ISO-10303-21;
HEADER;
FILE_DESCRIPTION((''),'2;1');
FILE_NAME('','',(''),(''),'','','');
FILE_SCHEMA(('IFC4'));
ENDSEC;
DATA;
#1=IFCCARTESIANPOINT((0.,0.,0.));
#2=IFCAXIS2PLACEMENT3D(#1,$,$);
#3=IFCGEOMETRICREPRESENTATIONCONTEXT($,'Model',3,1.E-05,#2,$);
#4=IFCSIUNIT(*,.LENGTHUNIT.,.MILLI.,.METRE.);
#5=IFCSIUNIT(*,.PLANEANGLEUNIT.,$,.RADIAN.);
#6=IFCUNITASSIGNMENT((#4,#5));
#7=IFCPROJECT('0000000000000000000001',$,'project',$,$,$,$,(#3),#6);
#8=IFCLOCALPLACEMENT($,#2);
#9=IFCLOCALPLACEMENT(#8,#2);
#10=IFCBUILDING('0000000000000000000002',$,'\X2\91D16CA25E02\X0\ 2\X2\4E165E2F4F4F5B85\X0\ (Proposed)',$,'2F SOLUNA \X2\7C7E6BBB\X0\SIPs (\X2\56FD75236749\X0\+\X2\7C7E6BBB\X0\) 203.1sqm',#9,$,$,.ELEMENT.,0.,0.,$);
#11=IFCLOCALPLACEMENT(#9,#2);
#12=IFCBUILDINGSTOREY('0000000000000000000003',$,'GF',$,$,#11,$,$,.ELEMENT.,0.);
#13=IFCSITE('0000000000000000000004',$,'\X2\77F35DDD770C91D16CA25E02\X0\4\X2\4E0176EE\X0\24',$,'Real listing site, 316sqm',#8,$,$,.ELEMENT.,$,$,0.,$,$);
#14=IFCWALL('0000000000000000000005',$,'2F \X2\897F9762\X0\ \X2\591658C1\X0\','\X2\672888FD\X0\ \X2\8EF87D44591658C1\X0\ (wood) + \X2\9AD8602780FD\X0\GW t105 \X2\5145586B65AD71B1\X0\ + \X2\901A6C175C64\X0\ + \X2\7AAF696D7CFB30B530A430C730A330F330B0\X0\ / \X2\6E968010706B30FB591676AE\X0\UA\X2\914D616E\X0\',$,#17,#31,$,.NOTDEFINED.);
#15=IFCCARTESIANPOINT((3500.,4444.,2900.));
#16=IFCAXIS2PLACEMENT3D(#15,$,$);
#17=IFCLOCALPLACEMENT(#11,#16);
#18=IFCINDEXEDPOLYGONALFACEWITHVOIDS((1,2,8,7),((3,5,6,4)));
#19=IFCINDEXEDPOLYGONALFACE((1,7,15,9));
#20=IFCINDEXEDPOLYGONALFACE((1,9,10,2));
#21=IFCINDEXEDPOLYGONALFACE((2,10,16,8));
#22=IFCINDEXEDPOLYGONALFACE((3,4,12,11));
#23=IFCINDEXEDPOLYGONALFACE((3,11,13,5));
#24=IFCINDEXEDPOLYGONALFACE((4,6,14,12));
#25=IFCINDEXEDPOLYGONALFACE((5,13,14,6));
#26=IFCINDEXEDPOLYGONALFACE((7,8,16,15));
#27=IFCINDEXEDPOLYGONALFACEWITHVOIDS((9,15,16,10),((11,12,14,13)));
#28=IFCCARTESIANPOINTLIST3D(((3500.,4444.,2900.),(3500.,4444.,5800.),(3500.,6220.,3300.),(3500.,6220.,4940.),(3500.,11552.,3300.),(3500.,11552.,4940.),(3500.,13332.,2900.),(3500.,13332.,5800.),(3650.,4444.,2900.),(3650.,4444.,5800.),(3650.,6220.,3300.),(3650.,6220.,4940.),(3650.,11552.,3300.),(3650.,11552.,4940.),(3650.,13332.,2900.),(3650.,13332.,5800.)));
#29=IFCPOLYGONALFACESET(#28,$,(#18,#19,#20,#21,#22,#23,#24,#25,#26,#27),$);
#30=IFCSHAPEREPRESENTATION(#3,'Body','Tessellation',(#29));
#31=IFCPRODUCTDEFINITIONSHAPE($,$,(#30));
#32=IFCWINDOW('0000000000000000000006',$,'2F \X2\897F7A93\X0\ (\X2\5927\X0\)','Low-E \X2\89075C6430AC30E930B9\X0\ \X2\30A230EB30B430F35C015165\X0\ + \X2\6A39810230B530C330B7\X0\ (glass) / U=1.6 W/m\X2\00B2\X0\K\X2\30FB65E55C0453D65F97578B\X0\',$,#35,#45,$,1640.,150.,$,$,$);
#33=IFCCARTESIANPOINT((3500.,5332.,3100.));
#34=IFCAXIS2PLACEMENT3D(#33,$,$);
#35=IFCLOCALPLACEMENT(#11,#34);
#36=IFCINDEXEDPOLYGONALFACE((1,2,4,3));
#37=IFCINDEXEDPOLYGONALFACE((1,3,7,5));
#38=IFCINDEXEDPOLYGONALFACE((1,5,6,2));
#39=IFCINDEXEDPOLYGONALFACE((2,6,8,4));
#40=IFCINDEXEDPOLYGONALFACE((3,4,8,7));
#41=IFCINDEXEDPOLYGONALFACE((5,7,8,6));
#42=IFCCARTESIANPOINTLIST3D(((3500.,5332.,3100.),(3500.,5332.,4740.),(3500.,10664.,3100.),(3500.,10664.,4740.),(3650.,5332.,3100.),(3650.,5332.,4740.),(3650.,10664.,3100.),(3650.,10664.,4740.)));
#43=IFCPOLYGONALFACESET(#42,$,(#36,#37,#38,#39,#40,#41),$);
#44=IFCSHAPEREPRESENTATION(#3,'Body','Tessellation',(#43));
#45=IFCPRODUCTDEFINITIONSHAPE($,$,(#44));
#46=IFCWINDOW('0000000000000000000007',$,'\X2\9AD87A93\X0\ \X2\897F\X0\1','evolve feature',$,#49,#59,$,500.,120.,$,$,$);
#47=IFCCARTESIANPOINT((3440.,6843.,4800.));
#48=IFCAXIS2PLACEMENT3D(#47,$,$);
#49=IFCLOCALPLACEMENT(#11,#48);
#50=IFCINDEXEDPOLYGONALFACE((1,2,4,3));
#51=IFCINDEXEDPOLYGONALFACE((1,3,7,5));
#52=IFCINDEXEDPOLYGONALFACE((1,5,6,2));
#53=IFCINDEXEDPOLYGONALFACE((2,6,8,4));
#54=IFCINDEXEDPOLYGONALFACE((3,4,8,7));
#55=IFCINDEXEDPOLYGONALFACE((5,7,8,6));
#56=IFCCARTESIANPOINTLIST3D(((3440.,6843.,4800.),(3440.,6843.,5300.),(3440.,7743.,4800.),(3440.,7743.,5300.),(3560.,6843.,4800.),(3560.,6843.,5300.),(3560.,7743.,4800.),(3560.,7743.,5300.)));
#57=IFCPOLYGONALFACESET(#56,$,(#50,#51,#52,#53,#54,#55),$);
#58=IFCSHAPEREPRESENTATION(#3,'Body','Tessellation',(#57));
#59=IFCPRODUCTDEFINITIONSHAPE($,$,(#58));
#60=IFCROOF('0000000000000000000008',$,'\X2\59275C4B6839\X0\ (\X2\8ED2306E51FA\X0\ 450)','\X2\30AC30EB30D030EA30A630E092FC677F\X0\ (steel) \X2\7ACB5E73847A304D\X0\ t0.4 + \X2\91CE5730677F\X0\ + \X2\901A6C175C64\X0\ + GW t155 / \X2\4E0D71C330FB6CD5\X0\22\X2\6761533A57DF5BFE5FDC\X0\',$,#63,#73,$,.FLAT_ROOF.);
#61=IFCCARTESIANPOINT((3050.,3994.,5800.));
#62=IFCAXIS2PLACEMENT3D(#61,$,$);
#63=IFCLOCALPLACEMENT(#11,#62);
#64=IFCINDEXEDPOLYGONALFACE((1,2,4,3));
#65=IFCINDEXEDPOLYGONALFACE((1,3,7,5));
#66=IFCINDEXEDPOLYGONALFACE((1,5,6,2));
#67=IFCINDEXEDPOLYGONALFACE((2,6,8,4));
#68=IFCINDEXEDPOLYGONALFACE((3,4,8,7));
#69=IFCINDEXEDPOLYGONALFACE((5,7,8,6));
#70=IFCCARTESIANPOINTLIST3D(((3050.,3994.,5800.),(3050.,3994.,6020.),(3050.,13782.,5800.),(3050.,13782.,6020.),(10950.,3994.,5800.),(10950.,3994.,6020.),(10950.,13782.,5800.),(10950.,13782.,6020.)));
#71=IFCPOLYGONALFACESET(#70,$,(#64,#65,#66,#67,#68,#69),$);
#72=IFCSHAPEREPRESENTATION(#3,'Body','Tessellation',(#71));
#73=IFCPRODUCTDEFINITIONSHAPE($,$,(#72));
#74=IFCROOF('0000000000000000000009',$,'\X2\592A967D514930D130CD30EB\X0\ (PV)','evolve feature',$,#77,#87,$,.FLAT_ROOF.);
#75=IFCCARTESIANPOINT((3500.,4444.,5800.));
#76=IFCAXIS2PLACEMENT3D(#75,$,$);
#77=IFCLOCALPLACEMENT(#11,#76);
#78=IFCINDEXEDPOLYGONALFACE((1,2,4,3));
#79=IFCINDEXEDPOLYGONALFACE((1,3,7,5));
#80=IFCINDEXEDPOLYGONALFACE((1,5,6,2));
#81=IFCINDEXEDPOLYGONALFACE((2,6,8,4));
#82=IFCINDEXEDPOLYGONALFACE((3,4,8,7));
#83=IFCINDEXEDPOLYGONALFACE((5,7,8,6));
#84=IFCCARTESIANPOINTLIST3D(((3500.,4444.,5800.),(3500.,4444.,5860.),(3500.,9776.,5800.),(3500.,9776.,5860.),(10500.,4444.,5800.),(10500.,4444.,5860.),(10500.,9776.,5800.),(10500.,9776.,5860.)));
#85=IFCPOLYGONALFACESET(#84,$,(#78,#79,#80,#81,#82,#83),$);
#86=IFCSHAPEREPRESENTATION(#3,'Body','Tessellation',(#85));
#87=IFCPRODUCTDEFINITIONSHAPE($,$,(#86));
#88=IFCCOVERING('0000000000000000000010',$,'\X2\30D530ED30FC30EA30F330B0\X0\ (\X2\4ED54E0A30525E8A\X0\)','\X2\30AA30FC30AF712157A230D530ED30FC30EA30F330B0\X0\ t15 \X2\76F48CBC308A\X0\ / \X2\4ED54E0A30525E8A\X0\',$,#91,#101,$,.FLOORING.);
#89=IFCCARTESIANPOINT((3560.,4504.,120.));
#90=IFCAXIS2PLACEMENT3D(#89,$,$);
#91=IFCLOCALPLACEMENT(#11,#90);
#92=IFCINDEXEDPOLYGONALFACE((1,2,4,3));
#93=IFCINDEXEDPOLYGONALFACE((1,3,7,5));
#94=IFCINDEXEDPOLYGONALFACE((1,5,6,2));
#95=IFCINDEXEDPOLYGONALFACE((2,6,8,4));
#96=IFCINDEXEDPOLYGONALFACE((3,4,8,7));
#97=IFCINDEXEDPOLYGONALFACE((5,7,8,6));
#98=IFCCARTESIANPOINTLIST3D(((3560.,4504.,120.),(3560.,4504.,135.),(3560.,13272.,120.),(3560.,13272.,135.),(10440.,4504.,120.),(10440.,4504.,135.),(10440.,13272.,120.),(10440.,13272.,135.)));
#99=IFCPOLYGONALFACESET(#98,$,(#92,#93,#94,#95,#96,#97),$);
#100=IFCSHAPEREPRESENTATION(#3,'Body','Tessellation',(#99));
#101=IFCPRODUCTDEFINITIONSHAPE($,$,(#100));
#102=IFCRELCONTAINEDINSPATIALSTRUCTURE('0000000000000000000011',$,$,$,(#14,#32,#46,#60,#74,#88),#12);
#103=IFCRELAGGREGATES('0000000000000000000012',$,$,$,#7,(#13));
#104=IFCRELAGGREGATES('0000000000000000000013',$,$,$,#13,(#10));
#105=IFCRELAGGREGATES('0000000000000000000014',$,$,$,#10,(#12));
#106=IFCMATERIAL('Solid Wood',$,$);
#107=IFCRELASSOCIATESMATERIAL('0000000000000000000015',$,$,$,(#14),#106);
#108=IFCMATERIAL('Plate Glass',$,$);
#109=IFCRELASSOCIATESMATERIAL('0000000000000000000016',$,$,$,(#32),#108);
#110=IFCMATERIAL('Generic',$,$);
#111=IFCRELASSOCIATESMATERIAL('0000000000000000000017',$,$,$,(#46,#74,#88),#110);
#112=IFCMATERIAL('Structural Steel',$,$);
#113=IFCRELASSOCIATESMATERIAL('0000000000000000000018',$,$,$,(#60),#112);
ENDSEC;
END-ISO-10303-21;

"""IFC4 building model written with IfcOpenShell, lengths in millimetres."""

from ifc_helpers import new_model, si_unit, frame, frame_2d, origin, place, context, project, spatial, rectangle, extrude, material, element, fill, save


model = new_model("IFC4")

# Units and contexts
model_context = context("Model", 3, precision=1e-05, world=origin())
ifc_project = project(units=[si_unit("LENGTHUNIT", "METRE", prefix="MILLI"), si_unit("PLANEANGLEUNIT", "RADIAN")], contexts=[model_context])

# Site, building, storey
site_placement = place(None, origin())
site = spatial("IfcSite", under=ifc_project, at=site_placement, Name="石川県金沢市4丁目24", ObjectType="Real listing site, 316sqm", CompositionType="ELEMENT", RefElevation=0.0)
building_placement = place(site_placement, origin())
building = spatial("IfcBuilding", under=site, at=building_placement, Name="金沢市 2世帯住宅 (Proposed)", ObjectType="2F SOLUNA 籾殻SIPs (国産杉+籾殻) 203.1sqm", CompositionType="ELEMENT", ElevationOfRefHeight=0.0, ElevationOfTerrain=0.0)
storey_placement = place(building_placement, origin())
storey = spatial("IfcBuildingStorey", under=building, at=storey_placement, Name="GF", CompositionType="ELEMENT", Elevation=0.0)

# Shared definitions
ifc_material_1 = material(Name="Solid Wood")

# Shared definitions
ifc_material_2 = material(Name="Plate Glass")
ifc_material_3 = material(Name="Generic")

# Wall, openings, windows
wall_1_placement = place(storey_placement, frame((3500.0, 4444.0, 2900.0)))
wall_1 = element("IfcWall", 1, at=wall_1_placement, inside=storey, material=ifc_material_1, Name="2F 西面 外壁", Description="木製 軸組外壁 (wood) + 高性能GW t105 充填断熱 + 通気層 + 窯業系サイディング / 準耐火・外皮UA配慮", PredefinedType="NOTDEFINED", context=model_context, shape_type="SweptSolid", body=[
    extrude(rectangle(XDim=150.0, YDim=8888.0, at=frame_2d((75.0, 4444.0))), frame((3500.0, 4444.0, 2900.0)), (0.0, 0.0, 1.0), 2900.0),
])
opening_1_placement = place(storey_placement, frame((3500.0, 5332.0, 3100.0)))
opening_1 = element("IfcOpeningElement", 2, at=opening_1_placement, cuts=wall_1, PredefinedType="NOTDEFINED", context=model_context, shape_type="SweptSolid", body=[
    extrude(rectangle(XDim=150.0, YDim=5332.0, at=frame_2d((75.0, 2666.0))), frame((3500.0, 5332.0, 3100.0)), (0.0, 0.0, 1.0), 1640.0),
])
opening_2_placement = place(storey_placement, frame((3440.0, 6843.0, 4800.0)))
opening_2 = element("IfcOpeningElement", 3, at=opening_2_placement, cuts=wall_1, PredefinedType="NOTDEFINED", context=model_context, shape_type="SweptSolid", body=[
    extrude(rectangle(XDim=120.0, YDim=900.0, at=frame_2d((60.0, 450.0))), frame((3440.0, 6843.0, 4800.0)), (0.0, 0.0, 1.0), 500.0),
])
window_1_placement = place(storey_placement, frame((3500.0, 5332.0, 3100.0)))
window_1 = element("IfcWindow", 4, at=window_1_placement, inside=storey, material=ifc_material_2, Name="2F 西窓 (大)", Description="Low-E 複層ガラス アルゴン封入 + 樹脂サッシ (glass) / U=1.6 W/m²K・日射取得型", OverallHeight=1640.0, OverallWidth=150.0, context=model_context, shape_type="SweptSolid", body=[
    extrude(rectangle(XDim=150.0, YDim=5332.0, at=frame_2d((75.0, 2666.0))), frame((3500.0, 5332.0, 3100.0)), (0.0, 0.0, 1.0), 1640.0),
])
fill(opening_1, window_1)
window_2_placement = place(storey_placement, frame((3440.0, 6843.0, 4800.0)))
window_2 = element("IfcWindow", 5, at=window_2_placement, inside=storey, material=ifc_material_3, Name="高窓 西1", Description="evolve feature", OverallHeight=500.0, OverallWidth=120.0, context=model_context, shape_type="SweptSolid", body=[
    extrude(rectangle(XDim=120.0, YDim=900.0, at=frame_2d((60.0, 450.0))), frame((3440.0, 6843.0, 4800.0)), (0.0, 0.0, 1.0), 500.0),
])
fill(opening_2, window_2)

# Roofs
ifc_material_4 = material(Name="Structural Steel")
roof_1_placement = place(storey_placement, frame((3050.0, 3994.0, 5800.0)))
element("IfcRoof", 6, at=roof_1_placement, inside=storey, material=ifc_material_4, Name="大屋根 (軒の出 450)", Description="ガルバリウム鋼板 (steel) 立平葺き t0.4 + 野地板 + 通気層 + GW t155 / 不燃・法22条区域対応", PredefinedType="FLAT_ROOF", context=model_context, shape_type="SweptSolid", body=[
    extrude(rectangle(XDim=7900.0, YDim=9788.0, at=frame_2d((3950.0, 4894.0))), frame((3050.0, 3994.0, 5800.0)), (0.0, 0.0, 1.0), 220.0),
])
roof_2_placement = place(storey_placement, frame((3500.0, 4444.0, 5800.0)))
element("IfcRoof", 7, at=roof_2_placement, inside=storey, material=ifc_material_3, Name="太陽光パネル (PV)", Description="evolve feature", PredefinedType="FLAT_ROOF", context=model_context, shape_type="SweptSolid", body=[
    extrude(rectangle(XDim=7000.0, YDim=5332.0, at=frame_2d((3500.0, 2666.0))), frame((3500.0, 4444.0, 5800.0)), (0.0, 0.0, 1.0), 60.0),
])

# Covering
covering_placement = place(storey_placement, frame((3560.0, 4504.0, 120.0)))
element("IfcCovering", 8, at=covering_placement, inside=storey, material=ifc_material_3, Name="フローリング (仕上げ床)", Description="オーク無垢フローリング t15 直貼り / 仕上げ床", PredefinedType="FLOORING", context=model_context, shape_type="SweptSolid", body=[
    extrude(rectangle(XDim=6880.0, YDim=8768.0, at=frame_2d((3440.0, 4384.0))), frame((3560.0, 4504.0, 120.0)), (0.0, 0.0, 1.0), 15.0),
])

save(model, "model.ifc")
